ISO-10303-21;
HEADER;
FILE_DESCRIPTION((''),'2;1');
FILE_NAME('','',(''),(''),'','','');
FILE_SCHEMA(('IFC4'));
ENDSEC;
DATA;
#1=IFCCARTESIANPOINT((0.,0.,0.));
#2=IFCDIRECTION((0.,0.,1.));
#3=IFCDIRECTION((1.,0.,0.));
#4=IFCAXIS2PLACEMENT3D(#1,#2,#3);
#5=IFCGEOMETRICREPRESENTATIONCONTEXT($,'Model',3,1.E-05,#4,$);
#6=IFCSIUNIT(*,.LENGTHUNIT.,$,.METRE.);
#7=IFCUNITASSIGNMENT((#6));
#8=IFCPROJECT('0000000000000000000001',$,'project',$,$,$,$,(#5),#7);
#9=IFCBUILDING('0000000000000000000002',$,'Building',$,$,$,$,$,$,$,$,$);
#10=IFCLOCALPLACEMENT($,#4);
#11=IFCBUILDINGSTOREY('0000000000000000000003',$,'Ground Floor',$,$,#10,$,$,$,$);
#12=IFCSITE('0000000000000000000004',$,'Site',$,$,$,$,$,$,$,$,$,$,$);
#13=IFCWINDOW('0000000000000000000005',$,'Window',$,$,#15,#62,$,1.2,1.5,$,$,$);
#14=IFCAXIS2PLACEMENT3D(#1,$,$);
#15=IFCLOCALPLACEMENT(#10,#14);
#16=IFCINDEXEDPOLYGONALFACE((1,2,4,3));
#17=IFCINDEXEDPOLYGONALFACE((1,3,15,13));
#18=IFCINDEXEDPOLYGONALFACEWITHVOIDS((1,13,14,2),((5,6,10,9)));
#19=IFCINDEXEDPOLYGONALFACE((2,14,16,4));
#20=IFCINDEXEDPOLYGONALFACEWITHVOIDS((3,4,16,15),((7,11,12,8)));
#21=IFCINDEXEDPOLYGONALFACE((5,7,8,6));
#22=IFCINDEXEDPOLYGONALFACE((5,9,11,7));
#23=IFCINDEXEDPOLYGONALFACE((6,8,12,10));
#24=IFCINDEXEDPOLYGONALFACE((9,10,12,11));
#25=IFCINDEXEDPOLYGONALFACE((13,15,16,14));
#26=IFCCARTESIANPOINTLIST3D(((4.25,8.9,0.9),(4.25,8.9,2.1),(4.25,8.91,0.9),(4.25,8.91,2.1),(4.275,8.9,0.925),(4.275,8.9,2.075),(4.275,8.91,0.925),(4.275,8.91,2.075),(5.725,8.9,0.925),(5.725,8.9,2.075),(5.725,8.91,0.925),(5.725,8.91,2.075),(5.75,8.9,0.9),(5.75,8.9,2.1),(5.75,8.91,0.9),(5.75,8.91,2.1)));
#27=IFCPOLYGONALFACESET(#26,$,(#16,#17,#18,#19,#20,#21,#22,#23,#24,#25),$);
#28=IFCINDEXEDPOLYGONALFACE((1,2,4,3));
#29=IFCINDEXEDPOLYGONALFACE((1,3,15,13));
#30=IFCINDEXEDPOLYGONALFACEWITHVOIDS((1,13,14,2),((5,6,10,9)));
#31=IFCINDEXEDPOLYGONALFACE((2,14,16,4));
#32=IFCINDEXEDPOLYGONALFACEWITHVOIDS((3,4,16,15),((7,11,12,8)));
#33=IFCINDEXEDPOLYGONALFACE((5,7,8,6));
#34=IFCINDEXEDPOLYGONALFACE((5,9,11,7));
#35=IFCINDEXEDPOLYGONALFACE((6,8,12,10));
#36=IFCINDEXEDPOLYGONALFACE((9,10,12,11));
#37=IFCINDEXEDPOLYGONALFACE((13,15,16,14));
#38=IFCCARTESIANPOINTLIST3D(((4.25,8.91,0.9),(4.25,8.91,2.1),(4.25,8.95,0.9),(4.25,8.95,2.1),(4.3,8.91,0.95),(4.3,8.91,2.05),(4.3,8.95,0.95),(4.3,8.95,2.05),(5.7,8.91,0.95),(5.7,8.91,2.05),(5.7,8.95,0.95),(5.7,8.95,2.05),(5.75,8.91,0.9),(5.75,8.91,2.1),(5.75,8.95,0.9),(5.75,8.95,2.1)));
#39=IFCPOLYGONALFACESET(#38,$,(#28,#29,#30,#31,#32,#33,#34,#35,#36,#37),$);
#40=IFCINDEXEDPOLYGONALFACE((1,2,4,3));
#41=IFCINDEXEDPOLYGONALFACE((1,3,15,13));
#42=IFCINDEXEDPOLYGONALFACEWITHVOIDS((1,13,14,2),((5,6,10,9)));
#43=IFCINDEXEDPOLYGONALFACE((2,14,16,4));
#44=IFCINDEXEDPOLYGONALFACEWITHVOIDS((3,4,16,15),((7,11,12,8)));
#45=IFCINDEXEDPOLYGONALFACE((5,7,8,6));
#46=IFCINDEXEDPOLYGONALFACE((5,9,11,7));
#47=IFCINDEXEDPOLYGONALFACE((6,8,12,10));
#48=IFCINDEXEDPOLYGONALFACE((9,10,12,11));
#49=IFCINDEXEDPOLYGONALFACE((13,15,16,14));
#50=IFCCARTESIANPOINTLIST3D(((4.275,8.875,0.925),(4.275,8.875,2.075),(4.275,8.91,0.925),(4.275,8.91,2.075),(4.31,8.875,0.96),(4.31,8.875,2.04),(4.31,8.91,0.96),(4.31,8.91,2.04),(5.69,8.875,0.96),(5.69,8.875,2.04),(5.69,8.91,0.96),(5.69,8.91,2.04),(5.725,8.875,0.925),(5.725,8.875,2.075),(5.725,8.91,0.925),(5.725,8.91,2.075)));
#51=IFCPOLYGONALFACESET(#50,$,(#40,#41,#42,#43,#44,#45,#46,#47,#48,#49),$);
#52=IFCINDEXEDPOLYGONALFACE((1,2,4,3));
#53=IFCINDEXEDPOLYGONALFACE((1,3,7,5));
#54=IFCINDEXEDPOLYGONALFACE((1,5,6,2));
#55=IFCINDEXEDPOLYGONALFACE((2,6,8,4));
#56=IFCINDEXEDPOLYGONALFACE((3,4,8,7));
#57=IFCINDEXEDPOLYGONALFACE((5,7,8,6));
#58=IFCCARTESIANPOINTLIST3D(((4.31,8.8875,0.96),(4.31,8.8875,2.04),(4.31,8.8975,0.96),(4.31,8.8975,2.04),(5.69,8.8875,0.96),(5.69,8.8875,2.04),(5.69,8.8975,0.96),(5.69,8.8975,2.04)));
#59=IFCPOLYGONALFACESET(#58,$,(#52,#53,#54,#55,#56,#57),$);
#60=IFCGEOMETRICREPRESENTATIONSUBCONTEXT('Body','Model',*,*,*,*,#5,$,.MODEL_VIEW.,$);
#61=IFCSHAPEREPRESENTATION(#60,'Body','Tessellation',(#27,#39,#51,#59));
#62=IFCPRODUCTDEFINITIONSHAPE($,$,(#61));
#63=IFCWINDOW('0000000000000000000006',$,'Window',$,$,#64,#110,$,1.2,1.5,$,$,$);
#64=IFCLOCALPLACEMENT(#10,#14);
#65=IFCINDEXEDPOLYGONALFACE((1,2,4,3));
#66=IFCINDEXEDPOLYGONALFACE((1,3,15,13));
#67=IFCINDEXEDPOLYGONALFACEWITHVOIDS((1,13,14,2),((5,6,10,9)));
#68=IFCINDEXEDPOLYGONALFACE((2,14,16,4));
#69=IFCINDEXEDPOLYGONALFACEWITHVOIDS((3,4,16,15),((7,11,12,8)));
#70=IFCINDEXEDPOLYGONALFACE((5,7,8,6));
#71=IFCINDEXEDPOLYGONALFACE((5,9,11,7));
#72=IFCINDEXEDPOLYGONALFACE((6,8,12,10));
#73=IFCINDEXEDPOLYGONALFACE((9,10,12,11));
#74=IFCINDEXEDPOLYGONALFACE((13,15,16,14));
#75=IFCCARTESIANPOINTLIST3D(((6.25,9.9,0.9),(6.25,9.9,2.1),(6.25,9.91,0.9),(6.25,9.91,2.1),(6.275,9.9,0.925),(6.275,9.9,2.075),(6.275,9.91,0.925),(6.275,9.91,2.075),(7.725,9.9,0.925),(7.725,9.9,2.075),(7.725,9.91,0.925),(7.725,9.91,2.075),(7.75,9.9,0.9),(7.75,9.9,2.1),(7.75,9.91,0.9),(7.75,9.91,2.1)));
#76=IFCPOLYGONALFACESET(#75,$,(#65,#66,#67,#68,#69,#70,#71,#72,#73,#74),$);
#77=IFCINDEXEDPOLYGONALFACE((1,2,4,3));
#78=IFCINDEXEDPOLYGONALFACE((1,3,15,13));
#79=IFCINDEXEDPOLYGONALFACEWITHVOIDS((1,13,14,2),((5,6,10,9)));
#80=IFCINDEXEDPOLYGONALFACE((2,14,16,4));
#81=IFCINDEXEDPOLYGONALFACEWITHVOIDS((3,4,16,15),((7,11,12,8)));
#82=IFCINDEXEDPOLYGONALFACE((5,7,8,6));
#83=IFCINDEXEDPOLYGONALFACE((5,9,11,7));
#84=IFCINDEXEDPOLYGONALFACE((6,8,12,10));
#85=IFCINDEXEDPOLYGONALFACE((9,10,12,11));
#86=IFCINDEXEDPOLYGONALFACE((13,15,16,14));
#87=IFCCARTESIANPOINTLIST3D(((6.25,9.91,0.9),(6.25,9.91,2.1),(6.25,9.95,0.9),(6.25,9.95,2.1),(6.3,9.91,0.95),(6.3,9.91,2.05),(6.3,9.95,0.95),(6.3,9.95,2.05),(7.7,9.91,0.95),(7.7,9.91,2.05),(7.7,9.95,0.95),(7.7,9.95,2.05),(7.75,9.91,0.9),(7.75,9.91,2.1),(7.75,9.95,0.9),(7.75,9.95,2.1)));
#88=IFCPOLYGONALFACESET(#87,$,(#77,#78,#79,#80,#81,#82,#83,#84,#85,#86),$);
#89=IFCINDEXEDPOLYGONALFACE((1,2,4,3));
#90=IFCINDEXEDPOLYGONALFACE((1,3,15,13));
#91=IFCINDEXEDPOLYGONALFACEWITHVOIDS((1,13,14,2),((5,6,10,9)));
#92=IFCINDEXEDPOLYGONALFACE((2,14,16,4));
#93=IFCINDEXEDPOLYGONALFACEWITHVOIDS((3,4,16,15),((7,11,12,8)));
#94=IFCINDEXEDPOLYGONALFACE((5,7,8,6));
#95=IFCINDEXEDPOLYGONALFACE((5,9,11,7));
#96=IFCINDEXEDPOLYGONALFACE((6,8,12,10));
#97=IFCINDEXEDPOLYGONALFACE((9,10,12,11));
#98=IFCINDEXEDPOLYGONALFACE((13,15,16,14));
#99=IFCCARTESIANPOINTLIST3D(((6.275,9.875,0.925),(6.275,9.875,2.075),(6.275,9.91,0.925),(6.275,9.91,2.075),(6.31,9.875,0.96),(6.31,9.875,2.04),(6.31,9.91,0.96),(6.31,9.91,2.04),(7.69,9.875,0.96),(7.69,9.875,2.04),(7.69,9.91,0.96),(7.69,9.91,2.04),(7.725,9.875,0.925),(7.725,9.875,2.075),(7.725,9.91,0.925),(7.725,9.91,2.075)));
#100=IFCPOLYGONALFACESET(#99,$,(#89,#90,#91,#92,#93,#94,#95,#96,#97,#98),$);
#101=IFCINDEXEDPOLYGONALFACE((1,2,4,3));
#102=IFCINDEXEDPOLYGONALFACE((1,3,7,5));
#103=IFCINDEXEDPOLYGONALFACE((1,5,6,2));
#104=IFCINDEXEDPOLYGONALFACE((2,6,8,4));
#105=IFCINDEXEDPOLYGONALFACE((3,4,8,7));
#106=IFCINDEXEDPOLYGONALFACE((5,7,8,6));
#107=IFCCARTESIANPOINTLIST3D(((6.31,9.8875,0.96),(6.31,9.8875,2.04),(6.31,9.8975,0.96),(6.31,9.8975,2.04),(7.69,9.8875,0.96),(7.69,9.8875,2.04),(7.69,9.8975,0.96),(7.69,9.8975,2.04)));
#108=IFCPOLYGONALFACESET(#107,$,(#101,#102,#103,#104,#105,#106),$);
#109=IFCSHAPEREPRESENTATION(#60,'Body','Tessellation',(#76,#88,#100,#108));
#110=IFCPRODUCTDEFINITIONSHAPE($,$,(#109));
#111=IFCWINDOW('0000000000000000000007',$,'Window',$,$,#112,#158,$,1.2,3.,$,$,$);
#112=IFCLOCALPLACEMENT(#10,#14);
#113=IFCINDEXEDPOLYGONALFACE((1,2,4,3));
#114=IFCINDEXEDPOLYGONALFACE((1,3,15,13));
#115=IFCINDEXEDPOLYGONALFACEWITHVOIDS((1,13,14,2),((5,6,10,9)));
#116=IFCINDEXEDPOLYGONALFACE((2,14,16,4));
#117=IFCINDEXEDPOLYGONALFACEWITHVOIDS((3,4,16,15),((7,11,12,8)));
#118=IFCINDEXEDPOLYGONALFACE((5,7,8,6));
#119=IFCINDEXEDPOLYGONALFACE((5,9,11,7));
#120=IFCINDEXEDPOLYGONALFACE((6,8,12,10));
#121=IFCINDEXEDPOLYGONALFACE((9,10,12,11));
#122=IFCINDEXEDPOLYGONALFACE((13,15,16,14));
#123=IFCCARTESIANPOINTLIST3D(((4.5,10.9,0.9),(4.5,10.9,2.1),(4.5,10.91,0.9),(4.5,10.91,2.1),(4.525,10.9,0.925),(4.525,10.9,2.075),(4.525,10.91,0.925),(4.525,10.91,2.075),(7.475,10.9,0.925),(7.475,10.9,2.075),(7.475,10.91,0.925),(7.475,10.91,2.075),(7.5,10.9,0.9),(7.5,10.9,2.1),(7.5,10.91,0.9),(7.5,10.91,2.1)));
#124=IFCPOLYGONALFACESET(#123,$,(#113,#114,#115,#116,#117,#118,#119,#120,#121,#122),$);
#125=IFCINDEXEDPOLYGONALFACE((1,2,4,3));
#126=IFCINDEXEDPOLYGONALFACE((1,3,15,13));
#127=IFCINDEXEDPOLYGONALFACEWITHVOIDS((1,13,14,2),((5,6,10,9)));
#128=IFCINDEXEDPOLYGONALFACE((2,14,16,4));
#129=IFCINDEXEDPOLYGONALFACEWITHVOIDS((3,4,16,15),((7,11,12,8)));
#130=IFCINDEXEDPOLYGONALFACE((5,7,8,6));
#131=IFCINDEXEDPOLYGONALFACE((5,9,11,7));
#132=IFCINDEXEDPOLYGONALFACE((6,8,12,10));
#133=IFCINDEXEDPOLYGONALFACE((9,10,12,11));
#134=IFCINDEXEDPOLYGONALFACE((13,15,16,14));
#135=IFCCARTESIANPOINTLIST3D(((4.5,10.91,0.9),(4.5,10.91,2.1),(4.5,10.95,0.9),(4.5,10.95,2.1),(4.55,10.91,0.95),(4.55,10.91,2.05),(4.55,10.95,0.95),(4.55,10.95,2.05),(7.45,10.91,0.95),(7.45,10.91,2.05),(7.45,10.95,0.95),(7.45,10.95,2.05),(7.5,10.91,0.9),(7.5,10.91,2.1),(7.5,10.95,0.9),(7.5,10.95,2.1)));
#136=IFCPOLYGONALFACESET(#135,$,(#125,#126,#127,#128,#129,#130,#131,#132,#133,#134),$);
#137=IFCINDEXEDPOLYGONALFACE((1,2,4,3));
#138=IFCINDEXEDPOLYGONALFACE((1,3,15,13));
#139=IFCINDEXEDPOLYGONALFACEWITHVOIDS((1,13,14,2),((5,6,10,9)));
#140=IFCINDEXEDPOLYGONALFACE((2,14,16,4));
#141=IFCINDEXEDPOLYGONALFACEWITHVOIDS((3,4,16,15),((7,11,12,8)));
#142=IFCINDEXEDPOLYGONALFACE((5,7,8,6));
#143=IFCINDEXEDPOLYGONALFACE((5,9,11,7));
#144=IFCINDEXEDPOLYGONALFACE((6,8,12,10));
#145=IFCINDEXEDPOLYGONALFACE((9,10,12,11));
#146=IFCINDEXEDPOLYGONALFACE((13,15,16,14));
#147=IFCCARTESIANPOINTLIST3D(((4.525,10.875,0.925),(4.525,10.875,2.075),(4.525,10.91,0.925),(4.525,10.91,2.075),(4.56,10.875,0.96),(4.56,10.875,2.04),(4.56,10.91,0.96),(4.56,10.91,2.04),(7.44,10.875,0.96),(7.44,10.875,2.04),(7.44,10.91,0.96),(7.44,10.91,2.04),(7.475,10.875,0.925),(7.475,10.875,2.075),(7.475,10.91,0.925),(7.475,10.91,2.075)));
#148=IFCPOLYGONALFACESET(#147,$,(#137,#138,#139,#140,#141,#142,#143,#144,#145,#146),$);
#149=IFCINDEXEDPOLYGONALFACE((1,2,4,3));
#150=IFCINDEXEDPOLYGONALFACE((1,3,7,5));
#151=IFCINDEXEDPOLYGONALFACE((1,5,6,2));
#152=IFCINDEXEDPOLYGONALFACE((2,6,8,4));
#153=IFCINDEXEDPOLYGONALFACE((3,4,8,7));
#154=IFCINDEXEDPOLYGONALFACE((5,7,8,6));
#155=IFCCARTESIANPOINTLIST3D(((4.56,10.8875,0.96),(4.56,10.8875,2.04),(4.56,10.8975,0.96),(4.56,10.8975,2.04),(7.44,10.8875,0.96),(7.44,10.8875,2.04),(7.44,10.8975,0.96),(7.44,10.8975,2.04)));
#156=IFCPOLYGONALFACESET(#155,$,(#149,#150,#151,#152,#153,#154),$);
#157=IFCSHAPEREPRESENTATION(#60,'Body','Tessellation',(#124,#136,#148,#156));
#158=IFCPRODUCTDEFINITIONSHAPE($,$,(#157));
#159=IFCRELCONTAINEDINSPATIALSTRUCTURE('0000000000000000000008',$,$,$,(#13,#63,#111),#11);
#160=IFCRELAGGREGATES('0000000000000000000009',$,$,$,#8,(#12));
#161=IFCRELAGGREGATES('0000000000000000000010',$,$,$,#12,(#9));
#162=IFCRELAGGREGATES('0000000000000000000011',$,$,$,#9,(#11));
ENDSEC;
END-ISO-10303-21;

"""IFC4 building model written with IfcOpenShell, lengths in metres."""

from ifc_helpers import new_model, si_unit, frame, origin_with_axes, place, context, subcontext, project, spatial, line, indexed_curve, outline, extrude, element, save


model = new_model("IFC4")

# Units and contexts
model_context = context("Model", 3, precision=1e-05, world=origin_with_axes())
body_context = subcontext(model_context, "Body", "Model", "MODEL_VIEW")
ifc_project = project(units=[si_unit("LENGTHUNIT", "METRE")], contexts=[model_context])

# Site, building, storey
site = spatial("IfcSite", under=ifc_project, Name="Site")
building = spatial("IfcBuilding", under=site, Name="Building")
storey_placement = place(None, origin_with_axes())
storey = spatial("IfcBuildingStorey", under=building, at=storey_placement, Name="Ground Floor")

# Windows
for number, where, z_axis, x_axis, name in (
    (1, (5.75, 9.0, 0.9), (0.0, 0.0, 1.0), (-1.0, 0.0, 0.0), "Window"),
    (2, (7.75, 10.0, 0.9), (0.0, 0.0, 1.0), (-1.0, 0.0, 0.0), "Window"),
):
    element("IfcWindow", number, at=place(storey_placement, frame(where, z_axis=z_axis, x_axis=x_axis)), inside=storey, Name=name, OverallHeight=1.2, OverallWidth=1.5, context=body_context, shape_type="SweptSolid", body=[
        extrude(outline(indexed_curve([(0.0, 0.0), (1.5, 0.0), (1.5, 1.2), (0.0, 1.2)], segments=[line(1, 2, 3, 4, 1)]), holes=[indexed_curve([(0.025, 0.025), (1.475, 0.025), (1.475, 1.175), (0.025, 1.175)], segments=[line(1, 2, 3, 4, 1)])]), frame((0.0, 0.09, 0.0), z_axis=(0.0, -1.0, 0.0), x_axis=(1.0, 0.0, 0.0)), (0.0, 0.0, -1.0), 0.01),
        extrude(outline(indexed_curve([(0.0, 0.0), (1.5, 0.0), (1.5, 1.2), (0.0, 1.2)], segments=[line(1, 2, 3, 4, 1)]), holes=[indexed_curve([(0.05, 0.05), (1.45, 0.05), (1.45, 1.15), (0.05, 1.15)], segments=[line(1, 2, 3, 4, 1)])]), frame((0.0, 0.05, 0.0), z_axis=(0.0, -1.0, 0.0), x_axis=(1.0, 0.0, 0.0)), (0.0, 0.0, -1.0), 0.04),
        extrude(outline(indexed_curve([(0.0, 0.0), (1.45, 0.0), (1.45, 1.15), (0.0, 1.15)], segments=[line(1, 2, 3, 4, 1)]), holes=[indexed_curve([(0.035, 0.035), (1.415, 0.035), (1.415, 1.115), (0.035, 1.115)], segments=[line(1, 2, 3, 4, 1)])]), frame((0.025, 0.09, 0.025), z_axis=(0.0, -1.0, 0.0), x_axis=(1.0, 0.0, 0.0)), (0.0, 0.0, -1.0), 0.035),
        extrude(outline(indexed_curve([(0.035, 0.035), (1.415, 0.035), (1.415, 1.115), (0.035, 1.115)], segments=[line(1, 2, 3, 4, 1)])), frame((0.025, 0.1025, 0.025), z_axis=(0.0, -1.0, 0.0), x_axis=(1.0, 0.0, 0.0)), (0.0, 0.0, -1.0), 0.01),
    ])
window_placement = place(storey_placement, frame((7.5, 11.0, 0.9), z_axis=(0.0, 0.0, 1.0), x_axis=(-1.0, 0.0, 0.0)))
element("IfcWindow", 3, at=window_placement, inside=storey, Name="Window", OverallHeight=1.2, OverallWidth=3.0, context=body_context, shape_type="SweptSolid", body=[
    extrude(outline(indexed_curve([(0.0, 0.0), (3.0, 0.0), (3.0, 1.2), (0.0, 1.2)], segments=[line(1, 2, 3, 4, 1)]), holes=[indexed_curve([(0.025, 0.025), (2.975, 0.025), (2.975, 1.175), (0.025, 1.175)], segments=[line(1, 2, 3, 4, 1)])]), frame((0.0, 0.09, 0.0), z_axis=(0.0, -1.0, 0.0), x_axis=(1.0, 0.0, 0.0)), (0.0, 0.0, -1.0), 0.01),
    extrude(outline(indexed_curve([(0.0, 0.0), (3.0, 0.0), (3.0, 1.2), (0.0, 1.2)], segments=[line(1, 2, 3, 4, 1)]), holes=[indexed_curve([(0.05, 0.05), (2.95, 0.05), (2.95, 1.15), (0.05, 1.15)], segments=[line(1, 2, 3, 4, 1)])]), frame((0.0, 0.05, 0.0), z_axis=(0.0, -1.0, 0.0), x_axis=(1.0, 0.0, 0.0)), (0.0, 0.0, -1.0), 0.04),
    extrude(outline(indexed_curve([(0.0, 0.0), (2.95, 0.0), (2.95, 1.15), (0.0, 1.15)], segments=[line(1, 2, 3, 4, 1)]), holes=[indexed_curve([(0.035, 0.035), (2.915, 0.035), (2.915, 1.115), (0.035, 1.115)], segments=[line(1, 2, 3, 4, 1)])]), frame((0.025, 0.09, 0.025), z_axis=(0.0, -1.0, 0.0), x_axis=(1.0, 0.0, 0.0)), (0.0, 0.0, -1.0), 0.035),
    extrude(outline(indexed_curve([(0.035, 0.035), (2.915, 0.035), (2.915, 1.115), (0.035, 1.115)], segments=[line(1, 2, 3, 4, 1)])), frame((0.025, 0.1025, 0.025), z_axis=(0.0, -1.0, 0.0), x_axis=(1.0, 0.0, 0.0)), (0.0, 0.0, -1.0), 0.01),
])

save(model, "model.ifc")
